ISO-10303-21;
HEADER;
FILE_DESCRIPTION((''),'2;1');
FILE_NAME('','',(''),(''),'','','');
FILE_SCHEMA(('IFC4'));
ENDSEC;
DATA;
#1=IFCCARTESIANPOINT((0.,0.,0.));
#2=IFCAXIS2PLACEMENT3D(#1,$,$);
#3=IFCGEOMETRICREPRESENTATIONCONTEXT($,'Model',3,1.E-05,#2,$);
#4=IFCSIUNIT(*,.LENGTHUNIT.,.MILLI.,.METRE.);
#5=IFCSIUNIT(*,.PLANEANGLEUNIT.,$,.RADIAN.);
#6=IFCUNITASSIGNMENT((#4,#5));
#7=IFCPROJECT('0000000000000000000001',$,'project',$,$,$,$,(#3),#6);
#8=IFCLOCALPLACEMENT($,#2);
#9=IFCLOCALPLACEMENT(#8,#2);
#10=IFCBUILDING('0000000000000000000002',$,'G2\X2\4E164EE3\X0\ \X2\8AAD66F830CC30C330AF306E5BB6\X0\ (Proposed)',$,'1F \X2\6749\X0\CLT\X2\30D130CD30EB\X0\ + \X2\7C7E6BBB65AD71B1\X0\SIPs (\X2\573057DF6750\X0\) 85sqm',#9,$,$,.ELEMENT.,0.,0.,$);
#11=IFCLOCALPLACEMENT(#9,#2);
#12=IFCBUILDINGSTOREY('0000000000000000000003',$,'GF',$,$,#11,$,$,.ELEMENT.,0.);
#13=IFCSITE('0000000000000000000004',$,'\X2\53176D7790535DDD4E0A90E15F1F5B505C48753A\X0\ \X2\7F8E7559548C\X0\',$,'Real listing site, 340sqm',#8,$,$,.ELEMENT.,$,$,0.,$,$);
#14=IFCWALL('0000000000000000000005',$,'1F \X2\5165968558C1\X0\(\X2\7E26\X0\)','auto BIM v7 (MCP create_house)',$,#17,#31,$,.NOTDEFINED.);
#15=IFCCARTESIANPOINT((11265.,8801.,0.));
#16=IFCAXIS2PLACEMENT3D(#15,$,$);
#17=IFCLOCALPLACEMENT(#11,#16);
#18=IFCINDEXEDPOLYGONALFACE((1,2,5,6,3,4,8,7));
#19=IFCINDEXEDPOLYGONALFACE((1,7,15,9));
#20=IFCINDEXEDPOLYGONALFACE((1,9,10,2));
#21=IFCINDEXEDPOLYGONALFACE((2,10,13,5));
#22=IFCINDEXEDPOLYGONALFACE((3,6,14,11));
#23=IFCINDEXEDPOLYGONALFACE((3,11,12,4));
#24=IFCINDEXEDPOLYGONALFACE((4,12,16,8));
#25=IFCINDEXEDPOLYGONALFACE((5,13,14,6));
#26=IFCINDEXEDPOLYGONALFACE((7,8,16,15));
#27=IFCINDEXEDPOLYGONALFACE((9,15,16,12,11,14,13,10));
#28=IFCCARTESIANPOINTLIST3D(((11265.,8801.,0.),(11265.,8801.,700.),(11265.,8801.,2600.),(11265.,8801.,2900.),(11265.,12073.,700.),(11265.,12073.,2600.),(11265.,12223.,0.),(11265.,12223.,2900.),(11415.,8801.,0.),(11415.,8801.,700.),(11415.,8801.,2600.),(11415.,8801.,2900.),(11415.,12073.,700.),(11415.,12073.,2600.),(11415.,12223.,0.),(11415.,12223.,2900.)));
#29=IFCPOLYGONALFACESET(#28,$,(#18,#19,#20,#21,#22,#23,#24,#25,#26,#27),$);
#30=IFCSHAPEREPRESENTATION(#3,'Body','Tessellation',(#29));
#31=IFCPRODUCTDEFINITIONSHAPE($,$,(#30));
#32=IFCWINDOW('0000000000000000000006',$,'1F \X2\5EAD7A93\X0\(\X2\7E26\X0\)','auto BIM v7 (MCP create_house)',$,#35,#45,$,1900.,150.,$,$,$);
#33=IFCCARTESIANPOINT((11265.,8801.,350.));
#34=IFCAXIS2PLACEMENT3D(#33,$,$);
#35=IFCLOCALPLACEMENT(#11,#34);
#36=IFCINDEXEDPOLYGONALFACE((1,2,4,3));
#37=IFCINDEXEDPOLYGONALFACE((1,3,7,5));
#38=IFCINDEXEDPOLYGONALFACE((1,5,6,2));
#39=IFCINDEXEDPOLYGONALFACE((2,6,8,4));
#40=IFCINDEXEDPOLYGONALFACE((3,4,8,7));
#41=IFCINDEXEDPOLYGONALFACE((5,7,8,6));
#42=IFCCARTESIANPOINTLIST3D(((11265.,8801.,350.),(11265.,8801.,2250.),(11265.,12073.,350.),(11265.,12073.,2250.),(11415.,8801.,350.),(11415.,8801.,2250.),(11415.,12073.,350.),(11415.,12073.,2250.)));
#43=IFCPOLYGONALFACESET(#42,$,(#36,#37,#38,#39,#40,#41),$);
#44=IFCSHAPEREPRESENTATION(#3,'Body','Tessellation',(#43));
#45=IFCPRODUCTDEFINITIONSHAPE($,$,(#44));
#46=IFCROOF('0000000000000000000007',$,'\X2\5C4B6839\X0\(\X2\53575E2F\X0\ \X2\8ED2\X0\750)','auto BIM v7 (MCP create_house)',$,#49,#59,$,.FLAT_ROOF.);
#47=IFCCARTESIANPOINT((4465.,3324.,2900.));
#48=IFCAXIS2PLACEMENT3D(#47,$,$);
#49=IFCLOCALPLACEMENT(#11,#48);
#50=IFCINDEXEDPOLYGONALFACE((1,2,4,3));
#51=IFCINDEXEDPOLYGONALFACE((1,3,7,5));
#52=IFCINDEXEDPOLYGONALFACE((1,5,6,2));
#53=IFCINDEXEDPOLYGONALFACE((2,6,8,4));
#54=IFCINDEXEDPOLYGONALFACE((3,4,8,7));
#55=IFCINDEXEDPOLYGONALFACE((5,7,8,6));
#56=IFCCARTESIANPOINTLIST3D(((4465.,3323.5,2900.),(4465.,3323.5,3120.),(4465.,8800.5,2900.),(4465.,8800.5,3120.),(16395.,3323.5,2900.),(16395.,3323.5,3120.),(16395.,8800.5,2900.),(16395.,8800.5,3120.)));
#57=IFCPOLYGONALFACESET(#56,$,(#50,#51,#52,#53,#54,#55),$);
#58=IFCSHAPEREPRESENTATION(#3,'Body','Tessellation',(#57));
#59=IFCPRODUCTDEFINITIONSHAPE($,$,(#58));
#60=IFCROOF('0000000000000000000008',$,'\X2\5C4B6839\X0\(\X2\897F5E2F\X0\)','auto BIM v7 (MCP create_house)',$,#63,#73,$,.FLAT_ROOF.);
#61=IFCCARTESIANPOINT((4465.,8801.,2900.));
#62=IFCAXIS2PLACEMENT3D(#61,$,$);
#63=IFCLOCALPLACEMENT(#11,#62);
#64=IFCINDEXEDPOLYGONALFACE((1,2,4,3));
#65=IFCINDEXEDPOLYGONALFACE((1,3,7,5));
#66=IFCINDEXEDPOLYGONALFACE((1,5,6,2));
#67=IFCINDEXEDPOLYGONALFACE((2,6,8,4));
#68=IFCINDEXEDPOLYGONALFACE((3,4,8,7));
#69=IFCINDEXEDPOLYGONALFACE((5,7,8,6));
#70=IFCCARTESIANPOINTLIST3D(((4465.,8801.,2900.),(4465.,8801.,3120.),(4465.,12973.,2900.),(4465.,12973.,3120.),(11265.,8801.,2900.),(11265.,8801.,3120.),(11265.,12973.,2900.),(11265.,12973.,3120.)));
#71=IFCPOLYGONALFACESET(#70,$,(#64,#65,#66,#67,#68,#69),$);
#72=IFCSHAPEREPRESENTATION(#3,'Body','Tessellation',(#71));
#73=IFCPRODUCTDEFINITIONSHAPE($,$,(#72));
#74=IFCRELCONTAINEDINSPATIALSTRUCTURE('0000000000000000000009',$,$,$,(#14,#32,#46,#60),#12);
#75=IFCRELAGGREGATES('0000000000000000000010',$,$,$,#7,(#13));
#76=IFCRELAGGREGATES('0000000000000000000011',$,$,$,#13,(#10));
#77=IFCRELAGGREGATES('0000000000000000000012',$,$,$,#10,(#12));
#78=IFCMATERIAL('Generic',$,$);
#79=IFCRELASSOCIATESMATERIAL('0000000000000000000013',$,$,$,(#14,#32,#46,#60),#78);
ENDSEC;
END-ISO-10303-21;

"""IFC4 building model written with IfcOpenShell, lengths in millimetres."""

from ifc_helpers import new_model, si_unit, frame, frame_2d, origin, place, context, project, spatial, rectangle, extrude, material, element, fill, save


model = new_model("IFC4")

# Units and contexts
model_context = context("Model", 3, precision=1e-05, world=origin())
ifc_project = project(units=[si_unit("LENGTHUNIT", "METRE", prefix="MILLI"), si_unit("PLANEANGLEUNIT", "RADIAN")], contexts=[model_context])

# Site, building, storey
site_placement = place(None, origin())
site = spatial("IfcSite", under=ifc_project, at=site_placement, Name="北海道川上郡弟子屈町 美留和", ObjectType="Real listing site, 340sqm", CompositionType="ELEMENT", RefElevation=0.0)
building_placement = place(site_placement, origin())
building = spatial("IfcBuilding", under=site, at=building_placement, Name="G2世代 読書ヌックの家 (Proposed)", ObjectType="1F 杉CLTパネル + 籾殻断熱SIPs (地域材) 85sqm", CompositionType="ELEMENT", ElevationOfRefHeight=0.0, ElevationOfTerrain=0.0)
storey_placement = place(building_placement, origin())
storey = spatial("IfcBuildingStorey", under=building, at=storey_placement, Name="GF", CompositionType="ELEMENT", Elevation=0.0)

# Shared definitions
ifc_material = material(Name="Generic")

# Wall, opening, window
wall_1_placement = place(storey_placement, frame((11265.0, 8801.0, 0.0)))
wall_1 = element("IfcWall", 1, at=wall_1_placement, inside=storey, material=ifc_material, Name="1F 入隅壁(縦)", Description="auto BIM v7 (MCP create_house)", PredefinedType="NOTDEFINED", context=model_context, shape_type="SweptSolid", body=[
    extrude(rectangle(XDim=150.0, YDim=3422.0, at=frame_2d((75.0, 1711.0))), frame((11265.0, 8801.0, 0.0)), (0.0, 0.0, 1.0), 2900.0),
])
opening_1_placement = place(storey_placement, frame((11265.0, 8801.0, 350.0)))
opening_1 = element("IfcOpeningElement", 2, at=opening_1_placement, cuts=wall_1, PredefinedType="NOTDEFINED", context=model_context, shape_type="SweptSolid", body=[
    extrude(rectangle(XDim=150.0, YDim=3272.0, at=frame_2d((75.0, 1636.0))), frame((11265.0, 8801.0, 350.0)), (0.0, 0.0, 1.0), 1900.0),
])
window_1_placement = place(storey_placement, frame((11265.0, 8801.0, 350.0)))
window_1 = element("IfcWindow", 3, at=window_1_placement, inside=storey, material=ifc_material, Name="1F 庭窓(縦)", Description="auto BIM v7 (MCP create_house)", OverallHeight=1900.0, OverallWidth=150.0, context=model_context, shape_type="SweptSolid", body=[
    extrude(rectangle(XDim=150.0, YDim=3272.0, at=frame_2d((75.0, 1636.0))), frame((11265.0, 8801.0, 350.0)), (0.0, 0.0, 1.0), 1900.0),
])
fill(opening_1, window_1)

# Roofs
roof_1_placement = place(storey_placement, frame((4465.0, 3324.0, 2900.0)))
element("IfcRoof", 4, at=roof_1_placement, inside=storey, material=ifc_material, Name="屋根(南帯 軒750)", Description="auto BIM v7 (MCP create_house)", PredefinedType="FLAT_ROOF", context=model_context, shape_type="SweptSolid", body=[
    extrude(rectangle(XDim=11930.0, YDim=5477.0, at=frame_2d((5965.0, 2738.0))), frame((4465.0, 3324.0, 2900.0)), (0.0, 0.0, 1.0), 220.0),
])
roof_2_placement = place(storey_placement, frame((4465.0, 8801.0, 2900.0)))
element("IfcRoof", 5, at=roof_2_placement, inside=storey, material=ifc_material, Name="屋根(西帯)", Description="auto BIM v7 (MCP create_house)", PredefinedType="FLAT_ROOF", context=model_context, shape_type="SweptSolid", body=[
    extrude(rectangle(XDim=6800.0, YDim=4172.0, at=frame_2d((3400.0, 2086.0))), frame((4465.0, 8801.0, 2900.0)), (0.0, 0.0, 1.0), 220.0),
])

save(model, "model.ifc")
